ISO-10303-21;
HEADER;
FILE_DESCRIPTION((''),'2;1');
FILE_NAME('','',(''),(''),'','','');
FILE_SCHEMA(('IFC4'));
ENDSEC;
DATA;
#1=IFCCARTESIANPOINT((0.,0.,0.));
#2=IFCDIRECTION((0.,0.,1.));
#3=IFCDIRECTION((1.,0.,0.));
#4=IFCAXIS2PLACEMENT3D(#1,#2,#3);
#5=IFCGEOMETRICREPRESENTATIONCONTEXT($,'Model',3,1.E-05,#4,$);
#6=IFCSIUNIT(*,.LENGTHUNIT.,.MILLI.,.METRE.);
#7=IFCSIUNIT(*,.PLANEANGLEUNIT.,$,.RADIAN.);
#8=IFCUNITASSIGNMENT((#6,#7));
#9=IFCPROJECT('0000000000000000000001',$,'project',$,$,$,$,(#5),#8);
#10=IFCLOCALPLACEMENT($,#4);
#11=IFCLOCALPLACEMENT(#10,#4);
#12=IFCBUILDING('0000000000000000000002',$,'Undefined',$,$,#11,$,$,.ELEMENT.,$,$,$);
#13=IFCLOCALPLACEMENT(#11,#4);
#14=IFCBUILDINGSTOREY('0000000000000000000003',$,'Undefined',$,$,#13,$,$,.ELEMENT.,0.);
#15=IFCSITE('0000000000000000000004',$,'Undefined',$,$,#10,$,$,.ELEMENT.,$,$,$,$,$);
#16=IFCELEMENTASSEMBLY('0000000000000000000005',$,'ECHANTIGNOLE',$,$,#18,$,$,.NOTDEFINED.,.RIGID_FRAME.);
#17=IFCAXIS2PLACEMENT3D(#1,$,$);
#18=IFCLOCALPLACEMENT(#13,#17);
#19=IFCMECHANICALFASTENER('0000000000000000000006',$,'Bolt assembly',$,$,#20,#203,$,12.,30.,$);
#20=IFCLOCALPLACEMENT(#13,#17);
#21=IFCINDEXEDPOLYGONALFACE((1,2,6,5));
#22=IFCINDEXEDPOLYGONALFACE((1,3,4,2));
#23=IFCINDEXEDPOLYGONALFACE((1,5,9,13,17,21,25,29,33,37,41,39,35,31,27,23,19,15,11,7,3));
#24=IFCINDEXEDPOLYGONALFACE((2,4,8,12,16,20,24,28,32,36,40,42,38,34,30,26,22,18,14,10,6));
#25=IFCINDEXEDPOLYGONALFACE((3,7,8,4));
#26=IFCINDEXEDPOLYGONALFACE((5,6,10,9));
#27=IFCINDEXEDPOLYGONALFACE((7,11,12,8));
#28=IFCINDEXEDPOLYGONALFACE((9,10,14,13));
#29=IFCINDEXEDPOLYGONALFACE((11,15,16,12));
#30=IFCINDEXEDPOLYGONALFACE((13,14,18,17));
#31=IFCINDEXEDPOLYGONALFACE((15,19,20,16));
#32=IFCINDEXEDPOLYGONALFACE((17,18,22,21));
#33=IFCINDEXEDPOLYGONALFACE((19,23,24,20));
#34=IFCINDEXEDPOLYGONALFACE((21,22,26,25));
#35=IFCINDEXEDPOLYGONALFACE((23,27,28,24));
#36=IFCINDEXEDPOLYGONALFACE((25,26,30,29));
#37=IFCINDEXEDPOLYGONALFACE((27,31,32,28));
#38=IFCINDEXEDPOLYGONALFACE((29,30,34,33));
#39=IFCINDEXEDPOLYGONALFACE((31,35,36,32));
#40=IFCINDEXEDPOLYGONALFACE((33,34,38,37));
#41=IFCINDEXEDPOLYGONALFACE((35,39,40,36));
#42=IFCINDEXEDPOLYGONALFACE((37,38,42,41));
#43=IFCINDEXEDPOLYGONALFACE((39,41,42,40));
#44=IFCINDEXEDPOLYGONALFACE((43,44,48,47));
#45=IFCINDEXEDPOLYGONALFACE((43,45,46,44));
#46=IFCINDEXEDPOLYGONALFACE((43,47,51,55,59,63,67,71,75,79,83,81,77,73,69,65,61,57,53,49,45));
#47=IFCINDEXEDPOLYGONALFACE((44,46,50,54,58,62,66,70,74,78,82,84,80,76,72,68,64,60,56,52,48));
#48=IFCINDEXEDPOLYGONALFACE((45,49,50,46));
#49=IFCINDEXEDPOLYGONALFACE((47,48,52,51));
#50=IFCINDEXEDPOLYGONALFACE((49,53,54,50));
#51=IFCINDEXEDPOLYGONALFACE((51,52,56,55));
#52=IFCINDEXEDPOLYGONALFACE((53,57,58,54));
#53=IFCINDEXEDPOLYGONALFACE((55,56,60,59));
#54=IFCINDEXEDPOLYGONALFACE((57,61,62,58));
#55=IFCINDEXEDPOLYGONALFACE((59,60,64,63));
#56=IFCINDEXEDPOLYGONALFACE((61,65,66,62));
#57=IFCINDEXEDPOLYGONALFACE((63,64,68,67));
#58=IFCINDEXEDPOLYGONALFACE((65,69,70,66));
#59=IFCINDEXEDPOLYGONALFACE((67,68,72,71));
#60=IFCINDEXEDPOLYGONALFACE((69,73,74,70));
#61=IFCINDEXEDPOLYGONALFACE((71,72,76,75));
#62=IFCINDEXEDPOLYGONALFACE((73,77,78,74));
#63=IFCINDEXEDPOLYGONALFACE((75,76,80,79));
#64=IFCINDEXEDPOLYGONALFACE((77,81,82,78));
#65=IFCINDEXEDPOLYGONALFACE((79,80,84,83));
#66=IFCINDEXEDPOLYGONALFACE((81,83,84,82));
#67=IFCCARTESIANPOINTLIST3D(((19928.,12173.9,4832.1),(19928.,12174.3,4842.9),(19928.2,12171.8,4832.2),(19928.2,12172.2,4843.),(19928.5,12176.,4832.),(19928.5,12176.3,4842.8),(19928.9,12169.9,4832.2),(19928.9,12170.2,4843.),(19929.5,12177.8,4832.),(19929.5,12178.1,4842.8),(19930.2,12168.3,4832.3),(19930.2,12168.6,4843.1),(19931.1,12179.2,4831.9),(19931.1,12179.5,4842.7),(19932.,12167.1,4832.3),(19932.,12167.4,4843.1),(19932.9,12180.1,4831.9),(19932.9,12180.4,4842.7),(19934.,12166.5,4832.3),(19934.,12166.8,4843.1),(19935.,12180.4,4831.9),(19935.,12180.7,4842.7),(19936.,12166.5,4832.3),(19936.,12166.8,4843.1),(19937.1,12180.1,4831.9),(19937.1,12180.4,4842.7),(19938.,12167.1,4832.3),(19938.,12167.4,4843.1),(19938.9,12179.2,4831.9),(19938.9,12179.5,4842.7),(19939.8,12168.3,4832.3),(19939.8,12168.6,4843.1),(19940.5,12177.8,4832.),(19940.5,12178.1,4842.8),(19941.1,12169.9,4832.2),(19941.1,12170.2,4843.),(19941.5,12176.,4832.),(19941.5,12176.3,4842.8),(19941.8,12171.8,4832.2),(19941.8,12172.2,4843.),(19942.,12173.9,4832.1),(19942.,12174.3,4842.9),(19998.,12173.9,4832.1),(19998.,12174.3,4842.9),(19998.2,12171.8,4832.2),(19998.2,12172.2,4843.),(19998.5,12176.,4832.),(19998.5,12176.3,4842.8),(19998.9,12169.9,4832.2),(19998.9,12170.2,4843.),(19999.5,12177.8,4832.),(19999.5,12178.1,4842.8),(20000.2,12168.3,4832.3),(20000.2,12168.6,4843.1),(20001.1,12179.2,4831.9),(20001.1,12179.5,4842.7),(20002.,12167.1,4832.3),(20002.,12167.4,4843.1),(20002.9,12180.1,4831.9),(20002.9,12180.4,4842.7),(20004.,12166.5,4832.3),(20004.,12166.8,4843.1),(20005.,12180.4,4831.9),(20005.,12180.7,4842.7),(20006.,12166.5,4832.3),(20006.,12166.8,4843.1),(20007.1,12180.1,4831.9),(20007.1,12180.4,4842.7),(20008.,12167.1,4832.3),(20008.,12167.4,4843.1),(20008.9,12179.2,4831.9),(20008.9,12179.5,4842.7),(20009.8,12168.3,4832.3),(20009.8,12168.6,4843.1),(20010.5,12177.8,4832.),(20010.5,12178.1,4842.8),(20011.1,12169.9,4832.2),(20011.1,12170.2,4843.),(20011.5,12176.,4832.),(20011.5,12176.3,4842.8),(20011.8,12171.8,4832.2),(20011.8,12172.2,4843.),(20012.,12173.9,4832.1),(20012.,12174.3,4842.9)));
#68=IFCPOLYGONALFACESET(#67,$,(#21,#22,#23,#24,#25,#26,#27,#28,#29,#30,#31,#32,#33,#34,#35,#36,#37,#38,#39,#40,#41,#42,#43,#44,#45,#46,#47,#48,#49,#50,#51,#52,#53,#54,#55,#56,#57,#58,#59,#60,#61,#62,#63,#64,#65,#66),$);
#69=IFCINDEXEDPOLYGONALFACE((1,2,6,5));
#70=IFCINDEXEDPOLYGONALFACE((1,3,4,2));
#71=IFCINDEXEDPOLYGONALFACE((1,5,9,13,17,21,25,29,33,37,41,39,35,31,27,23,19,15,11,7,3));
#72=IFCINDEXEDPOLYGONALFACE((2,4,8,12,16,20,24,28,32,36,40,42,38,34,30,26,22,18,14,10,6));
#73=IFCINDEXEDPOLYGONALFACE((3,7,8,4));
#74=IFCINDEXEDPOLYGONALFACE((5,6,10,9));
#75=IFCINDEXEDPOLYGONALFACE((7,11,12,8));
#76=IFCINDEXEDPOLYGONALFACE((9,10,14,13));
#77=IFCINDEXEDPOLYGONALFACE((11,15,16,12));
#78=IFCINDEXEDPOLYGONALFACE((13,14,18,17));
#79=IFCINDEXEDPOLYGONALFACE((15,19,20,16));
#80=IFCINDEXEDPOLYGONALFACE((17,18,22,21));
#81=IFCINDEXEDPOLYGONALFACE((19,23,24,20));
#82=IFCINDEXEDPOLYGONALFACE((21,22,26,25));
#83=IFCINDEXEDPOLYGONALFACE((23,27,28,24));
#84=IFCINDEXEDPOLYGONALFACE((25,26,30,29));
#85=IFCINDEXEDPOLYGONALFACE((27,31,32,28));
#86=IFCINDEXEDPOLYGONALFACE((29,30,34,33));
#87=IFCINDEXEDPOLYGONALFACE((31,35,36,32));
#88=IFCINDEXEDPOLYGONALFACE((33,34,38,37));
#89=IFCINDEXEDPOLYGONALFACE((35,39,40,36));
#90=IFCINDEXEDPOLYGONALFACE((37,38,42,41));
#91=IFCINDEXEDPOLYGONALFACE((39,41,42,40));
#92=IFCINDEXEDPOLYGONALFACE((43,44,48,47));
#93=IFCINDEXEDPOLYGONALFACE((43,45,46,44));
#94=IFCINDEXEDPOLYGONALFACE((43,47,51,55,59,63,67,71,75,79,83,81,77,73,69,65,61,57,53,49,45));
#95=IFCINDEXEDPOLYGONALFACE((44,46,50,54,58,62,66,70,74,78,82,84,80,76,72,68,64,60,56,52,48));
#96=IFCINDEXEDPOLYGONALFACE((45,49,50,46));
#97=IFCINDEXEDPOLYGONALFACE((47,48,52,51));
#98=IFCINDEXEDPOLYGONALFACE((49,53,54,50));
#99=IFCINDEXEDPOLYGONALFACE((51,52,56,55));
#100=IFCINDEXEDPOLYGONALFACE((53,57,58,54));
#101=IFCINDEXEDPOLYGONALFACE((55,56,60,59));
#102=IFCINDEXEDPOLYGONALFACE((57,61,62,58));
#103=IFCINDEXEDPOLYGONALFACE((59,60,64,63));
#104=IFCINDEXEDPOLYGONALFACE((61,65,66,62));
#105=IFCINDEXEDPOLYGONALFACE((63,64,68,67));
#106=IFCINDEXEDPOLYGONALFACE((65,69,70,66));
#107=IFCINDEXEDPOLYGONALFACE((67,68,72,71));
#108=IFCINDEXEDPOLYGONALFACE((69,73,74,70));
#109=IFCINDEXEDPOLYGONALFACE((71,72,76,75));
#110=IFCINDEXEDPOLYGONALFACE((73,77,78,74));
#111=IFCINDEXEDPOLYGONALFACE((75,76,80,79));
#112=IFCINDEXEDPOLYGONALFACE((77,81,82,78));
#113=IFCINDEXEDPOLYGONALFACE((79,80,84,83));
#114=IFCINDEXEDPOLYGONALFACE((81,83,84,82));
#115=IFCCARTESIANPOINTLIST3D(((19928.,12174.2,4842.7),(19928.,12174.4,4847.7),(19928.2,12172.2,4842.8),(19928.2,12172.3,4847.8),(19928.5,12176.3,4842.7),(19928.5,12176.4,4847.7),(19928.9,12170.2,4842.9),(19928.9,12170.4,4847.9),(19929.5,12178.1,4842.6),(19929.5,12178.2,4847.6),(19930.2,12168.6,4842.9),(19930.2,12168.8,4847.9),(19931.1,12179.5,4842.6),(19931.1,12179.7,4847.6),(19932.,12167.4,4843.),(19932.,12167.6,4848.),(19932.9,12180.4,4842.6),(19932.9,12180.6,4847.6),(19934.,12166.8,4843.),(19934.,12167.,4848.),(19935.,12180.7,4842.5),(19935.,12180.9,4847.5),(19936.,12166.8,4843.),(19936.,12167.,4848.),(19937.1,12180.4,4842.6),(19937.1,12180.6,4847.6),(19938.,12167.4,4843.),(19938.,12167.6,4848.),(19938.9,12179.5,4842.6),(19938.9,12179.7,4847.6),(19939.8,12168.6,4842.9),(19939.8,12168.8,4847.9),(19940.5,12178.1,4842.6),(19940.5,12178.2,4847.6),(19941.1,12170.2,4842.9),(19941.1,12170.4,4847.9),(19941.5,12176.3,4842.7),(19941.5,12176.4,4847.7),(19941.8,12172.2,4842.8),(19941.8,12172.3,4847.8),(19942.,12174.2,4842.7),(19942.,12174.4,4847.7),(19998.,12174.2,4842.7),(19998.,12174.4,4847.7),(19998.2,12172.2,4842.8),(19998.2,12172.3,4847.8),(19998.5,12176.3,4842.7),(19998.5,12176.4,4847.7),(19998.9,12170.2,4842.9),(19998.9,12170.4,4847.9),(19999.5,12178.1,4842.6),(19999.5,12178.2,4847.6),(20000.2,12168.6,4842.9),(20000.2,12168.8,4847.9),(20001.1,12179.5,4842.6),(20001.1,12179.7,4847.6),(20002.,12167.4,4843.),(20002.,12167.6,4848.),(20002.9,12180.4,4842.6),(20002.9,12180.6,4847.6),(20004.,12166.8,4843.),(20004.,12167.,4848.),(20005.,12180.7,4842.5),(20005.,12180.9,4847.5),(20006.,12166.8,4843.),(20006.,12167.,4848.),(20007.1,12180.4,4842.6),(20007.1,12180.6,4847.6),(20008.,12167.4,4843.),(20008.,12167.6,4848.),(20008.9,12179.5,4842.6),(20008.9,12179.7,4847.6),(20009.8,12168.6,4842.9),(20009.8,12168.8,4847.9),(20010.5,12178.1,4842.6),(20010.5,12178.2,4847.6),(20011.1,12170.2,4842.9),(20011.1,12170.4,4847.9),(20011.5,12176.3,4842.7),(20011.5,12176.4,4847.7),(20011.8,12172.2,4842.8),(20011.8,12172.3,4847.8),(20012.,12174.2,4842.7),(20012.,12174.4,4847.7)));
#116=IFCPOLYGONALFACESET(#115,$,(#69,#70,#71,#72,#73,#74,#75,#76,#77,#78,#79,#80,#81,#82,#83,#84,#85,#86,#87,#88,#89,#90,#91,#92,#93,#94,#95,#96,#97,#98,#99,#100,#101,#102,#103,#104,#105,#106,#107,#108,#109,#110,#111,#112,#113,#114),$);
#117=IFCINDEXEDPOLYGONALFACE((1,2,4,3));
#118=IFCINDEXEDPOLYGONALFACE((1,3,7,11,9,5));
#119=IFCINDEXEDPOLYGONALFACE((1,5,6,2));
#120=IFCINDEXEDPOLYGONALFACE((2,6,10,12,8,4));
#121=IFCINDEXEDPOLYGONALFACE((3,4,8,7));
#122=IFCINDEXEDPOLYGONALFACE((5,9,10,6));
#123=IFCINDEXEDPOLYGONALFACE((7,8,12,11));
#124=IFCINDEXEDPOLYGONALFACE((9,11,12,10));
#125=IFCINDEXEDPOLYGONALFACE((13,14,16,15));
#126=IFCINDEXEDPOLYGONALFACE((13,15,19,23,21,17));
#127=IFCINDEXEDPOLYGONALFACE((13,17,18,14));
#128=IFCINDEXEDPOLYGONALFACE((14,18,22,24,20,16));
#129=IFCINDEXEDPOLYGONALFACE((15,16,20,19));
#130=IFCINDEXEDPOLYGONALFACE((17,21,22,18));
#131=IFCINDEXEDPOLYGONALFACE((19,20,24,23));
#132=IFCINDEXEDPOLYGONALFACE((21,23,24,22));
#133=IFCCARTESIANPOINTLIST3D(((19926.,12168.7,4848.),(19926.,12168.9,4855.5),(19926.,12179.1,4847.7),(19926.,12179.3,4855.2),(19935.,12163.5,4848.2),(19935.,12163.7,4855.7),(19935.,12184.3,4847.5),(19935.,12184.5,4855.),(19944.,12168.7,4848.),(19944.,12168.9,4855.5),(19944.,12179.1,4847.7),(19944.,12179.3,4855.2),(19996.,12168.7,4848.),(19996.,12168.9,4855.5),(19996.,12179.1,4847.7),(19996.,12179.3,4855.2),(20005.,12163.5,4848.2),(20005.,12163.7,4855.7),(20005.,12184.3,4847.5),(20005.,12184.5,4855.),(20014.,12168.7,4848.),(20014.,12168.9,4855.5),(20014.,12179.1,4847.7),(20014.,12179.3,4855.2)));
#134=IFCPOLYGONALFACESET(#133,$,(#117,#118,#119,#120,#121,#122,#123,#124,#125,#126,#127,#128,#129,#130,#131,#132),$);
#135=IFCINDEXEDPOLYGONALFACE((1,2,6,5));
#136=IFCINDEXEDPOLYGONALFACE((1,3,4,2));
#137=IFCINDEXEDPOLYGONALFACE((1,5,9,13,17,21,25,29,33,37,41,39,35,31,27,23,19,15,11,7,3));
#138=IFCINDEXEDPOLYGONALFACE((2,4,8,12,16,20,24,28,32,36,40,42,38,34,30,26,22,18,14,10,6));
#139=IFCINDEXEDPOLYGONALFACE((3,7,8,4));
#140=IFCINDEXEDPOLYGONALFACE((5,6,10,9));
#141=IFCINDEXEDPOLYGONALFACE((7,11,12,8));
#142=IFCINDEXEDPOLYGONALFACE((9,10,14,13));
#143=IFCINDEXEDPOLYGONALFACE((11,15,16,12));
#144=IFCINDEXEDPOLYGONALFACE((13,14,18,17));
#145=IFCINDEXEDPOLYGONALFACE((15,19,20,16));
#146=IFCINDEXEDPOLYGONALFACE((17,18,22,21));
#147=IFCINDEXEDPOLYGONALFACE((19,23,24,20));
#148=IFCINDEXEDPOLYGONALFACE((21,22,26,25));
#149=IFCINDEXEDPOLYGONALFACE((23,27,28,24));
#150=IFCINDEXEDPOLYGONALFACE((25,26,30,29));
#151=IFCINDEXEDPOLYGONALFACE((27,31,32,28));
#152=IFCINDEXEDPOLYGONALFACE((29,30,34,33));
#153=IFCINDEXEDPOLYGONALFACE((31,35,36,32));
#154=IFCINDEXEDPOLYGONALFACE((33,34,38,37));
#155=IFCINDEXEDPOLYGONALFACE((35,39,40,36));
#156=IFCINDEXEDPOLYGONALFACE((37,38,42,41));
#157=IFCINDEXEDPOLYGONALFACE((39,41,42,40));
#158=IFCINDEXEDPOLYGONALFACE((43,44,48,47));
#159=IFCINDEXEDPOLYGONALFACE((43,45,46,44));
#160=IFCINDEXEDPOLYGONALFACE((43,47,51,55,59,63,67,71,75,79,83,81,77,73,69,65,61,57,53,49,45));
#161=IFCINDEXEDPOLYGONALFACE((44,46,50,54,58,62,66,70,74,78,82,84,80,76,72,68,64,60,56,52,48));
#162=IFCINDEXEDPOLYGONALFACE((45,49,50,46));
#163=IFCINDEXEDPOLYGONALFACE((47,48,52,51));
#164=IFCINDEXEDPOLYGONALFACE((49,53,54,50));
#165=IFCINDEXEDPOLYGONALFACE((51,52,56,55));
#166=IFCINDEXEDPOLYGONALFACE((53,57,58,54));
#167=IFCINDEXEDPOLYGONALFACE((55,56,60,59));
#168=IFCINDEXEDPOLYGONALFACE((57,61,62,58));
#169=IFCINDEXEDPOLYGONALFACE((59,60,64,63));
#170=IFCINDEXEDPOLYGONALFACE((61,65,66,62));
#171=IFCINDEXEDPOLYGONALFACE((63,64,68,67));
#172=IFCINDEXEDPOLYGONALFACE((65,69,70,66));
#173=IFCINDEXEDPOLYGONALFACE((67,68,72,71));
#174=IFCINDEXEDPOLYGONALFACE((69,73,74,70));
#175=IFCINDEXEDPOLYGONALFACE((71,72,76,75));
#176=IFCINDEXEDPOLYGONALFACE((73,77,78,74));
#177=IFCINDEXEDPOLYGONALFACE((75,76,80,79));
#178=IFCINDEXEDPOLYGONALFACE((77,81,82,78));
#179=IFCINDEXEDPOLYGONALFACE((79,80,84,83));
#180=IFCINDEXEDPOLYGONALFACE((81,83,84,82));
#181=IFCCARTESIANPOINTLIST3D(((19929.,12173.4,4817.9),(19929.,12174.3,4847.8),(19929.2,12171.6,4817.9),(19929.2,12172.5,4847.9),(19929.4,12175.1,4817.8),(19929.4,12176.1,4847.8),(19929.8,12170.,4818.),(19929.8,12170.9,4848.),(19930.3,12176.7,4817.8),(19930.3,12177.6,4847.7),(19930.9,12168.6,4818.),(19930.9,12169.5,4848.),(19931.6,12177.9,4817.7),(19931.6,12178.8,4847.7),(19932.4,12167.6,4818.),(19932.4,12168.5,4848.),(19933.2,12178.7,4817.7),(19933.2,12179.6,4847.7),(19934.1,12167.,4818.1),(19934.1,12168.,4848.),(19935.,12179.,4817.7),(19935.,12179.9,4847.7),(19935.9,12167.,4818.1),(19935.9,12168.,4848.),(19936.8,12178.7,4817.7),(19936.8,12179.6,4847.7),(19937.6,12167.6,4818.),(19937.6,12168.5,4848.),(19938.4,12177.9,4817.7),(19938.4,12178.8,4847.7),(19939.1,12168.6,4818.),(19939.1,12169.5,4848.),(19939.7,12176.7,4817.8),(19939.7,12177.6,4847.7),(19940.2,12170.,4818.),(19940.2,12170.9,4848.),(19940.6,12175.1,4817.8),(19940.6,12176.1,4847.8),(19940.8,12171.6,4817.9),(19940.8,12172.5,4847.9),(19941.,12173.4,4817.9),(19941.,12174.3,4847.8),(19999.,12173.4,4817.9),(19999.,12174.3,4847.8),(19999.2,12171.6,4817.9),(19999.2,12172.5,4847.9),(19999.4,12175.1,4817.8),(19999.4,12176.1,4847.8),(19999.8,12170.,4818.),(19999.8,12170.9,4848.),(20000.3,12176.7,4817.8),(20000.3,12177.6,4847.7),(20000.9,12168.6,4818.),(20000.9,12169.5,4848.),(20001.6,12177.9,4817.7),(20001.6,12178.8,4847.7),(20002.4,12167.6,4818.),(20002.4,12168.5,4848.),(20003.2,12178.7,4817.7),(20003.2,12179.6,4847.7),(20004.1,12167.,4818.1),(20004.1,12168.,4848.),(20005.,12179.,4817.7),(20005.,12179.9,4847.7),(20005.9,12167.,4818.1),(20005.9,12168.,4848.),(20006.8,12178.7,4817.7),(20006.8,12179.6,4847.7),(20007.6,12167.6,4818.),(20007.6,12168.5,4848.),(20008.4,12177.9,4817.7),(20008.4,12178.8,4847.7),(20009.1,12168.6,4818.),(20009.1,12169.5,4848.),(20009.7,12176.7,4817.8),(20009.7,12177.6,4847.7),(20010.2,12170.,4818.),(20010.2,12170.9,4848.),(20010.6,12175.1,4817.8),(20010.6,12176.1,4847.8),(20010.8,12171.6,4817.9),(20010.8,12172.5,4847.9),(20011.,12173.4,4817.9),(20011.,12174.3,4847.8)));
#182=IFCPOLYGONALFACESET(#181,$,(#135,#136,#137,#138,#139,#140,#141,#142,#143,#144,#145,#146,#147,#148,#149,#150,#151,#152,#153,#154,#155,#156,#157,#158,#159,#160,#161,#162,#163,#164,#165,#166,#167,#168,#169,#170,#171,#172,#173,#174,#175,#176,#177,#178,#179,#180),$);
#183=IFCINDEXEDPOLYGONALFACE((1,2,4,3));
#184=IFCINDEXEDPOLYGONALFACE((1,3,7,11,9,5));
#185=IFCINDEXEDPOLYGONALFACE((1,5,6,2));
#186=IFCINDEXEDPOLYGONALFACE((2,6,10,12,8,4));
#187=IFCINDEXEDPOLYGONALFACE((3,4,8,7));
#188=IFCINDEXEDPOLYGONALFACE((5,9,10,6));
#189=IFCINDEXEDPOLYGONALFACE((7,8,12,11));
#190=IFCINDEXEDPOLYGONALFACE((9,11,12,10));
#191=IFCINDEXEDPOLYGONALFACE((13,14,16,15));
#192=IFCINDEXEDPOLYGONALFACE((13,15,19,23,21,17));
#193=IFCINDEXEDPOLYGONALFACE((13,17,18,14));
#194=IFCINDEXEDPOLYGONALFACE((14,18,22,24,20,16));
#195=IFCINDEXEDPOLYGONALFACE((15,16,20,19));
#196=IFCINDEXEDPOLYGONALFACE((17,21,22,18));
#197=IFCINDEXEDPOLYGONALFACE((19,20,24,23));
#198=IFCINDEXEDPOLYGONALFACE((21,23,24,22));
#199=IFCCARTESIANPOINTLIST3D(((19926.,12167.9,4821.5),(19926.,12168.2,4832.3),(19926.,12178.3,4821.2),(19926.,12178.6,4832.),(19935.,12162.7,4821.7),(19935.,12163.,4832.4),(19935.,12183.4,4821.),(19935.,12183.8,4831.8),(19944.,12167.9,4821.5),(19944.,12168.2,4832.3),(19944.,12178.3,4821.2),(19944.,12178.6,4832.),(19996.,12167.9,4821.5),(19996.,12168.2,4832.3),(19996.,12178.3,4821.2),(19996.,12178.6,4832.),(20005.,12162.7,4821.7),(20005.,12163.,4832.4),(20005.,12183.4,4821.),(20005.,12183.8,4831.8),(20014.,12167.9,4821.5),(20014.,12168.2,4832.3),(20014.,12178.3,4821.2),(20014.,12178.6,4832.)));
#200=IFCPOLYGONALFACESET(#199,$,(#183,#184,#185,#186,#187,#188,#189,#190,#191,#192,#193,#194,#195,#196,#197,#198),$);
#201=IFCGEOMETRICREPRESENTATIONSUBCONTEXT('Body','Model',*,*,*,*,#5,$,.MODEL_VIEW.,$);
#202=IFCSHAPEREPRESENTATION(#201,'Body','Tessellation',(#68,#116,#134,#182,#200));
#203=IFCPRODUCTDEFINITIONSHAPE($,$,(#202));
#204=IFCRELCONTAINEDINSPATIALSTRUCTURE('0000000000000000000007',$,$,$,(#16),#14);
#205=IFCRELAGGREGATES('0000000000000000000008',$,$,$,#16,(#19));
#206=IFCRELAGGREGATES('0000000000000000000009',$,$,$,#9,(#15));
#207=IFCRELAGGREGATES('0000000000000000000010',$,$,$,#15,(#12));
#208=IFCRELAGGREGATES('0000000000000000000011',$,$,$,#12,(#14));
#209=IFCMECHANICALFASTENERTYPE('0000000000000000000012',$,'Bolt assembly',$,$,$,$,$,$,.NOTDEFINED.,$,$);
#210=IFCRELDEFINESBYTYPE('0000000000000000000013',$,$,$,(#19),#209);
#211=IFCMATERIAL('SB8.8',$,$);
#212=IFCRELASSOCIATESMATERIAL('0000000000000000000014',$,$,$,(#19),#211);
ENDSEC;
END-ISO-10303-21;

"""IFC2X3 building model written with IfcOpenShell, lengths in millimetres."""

from ifc_helpers import new_model, si_unit, frame, origin_with_axes, origin_2d_with_axis, place, context, subcontext, project, spatial, polyline, circle, outline, extrude, source, transform, mapped, material, type_object, element, aggregate, save


model = new_model("IFC2X3")

# Units and contexts
model_context = context("Model", 3, precision=1e-05, world=origin_with_axes())
body_context = subcontext(model_context, "Body", "Model", "MODEL_VIEW")
ifc_project = project(units=[si_unit("LENGTHUNIT", "METRE", prefix="MILLI"), si_unit("PLANEANGLEUNIT", "RADIAN")], contexts=[model_context])

# Site, building, storey
site_placement = place(None, origin_with_axes())
site = spatial("IfcSite", under=ifc_project, at=site_placement, Name="Undefined", CompositionType="ELEMENT")
building_placement = place(site_placement, origin_with_axes())
building = spatial("IfcBuilding", under=site, at=building_placement, Name="Undefined", CompositionType="ELEMENT")
storey_placement = place(building_placement, origin_with_axes())
storey = spatial("IfcBuildingStorey", under=building, at=storey_placement, Name="Undefined", CompositionType="ELEMENT", Elevation=0.0)

# Element assembly, mechanical fastener
assembly_1_placement = place(storey_placement, origin_with_axes())
assembly_1 = element("IfcElementAssembly", 1, at=assembly_1_placement, inside=storey, Name="ECHANTIGNOLE", AssemblyPlace="NOTDEFINED", PredefinedType="RIGID_FRAME")
ifc_material_1 = material(Name="SB8.8")
mechanical_fastener_type = type_object("IfcMechanicalFastenerType", Name="Bolt assembly")
shared_shape_1 = source(origin_with_axes(), body_context, "Body", "SweptSolid", [
    extrude(circle(Radius=7.0, at=origin_2d_with_axis()), frame((0.0, -0.1, 0.0), z_axis=(0.0, 1.0, 0.0), x_axis=(1.0, 0.0, 0.0)), (0.0, 0.0, 1.0), 10.8),
    extrude(circle(Radius=7.0, at=origin_2d_with_axis()), frame((0.0, -4.9, 0.0), z_axis=(0.0, 1.0, 0.0), x_axis=(1.0, 0.0, 0.0)), (0.0, 0.0, 1.0), 5.0),
    extrude(outline(polyline([(10.4, 0.0), (5.2, 9.0), (-5.2, 9.0), (-10.4, 0.0), (-5.2, -9.0), (5.2, -9.0), (10.4, 0.0)])), frame((0.0, -12.5, 0.0), z_axis=(0.0, 1.0, 0.0), x_axis=(1.0, 0.0, 0.0)), (0.0, 0.0, 1.0), 7.5),
    extrude(circle(Radius=6.0, at=origin_2d_with_axis()), frame((0.0, -5.0, 0.0), z_axis=(0.0, 1.0, 0.0), x_axis=(1.0, 0.0, 0.0)), (0.0, 0.0, 1.0), 30.0),
    extrude(outline(polyline([(10.4, 0.0), (5.2, 9.0), (-5.2, 9.0), (-10.4, 0.0), (-5.2, -9.0), (5.2, -9.0), (10.4, 0.0)])), frame((0.0, 10.7, 0.0), z_axis=(0.0, 1.0, 0.0), x_axis=(1.0, 0.0, 0.0)), (0.0, 0.0, 1.0), 10.8),
])
mechanical_fastener_1_placement = place(assembly_1_placement, frame((19970.0, 12173.7, 4842.9), z_axis=(-1.0, 0.0, 0.0), x_axis=(0.0, 0.99952, -0.030986)))
mechanical_fastener_1 = element("IfcMechanicalFastener", 2, at=mechanical_fastener_1_placement, type_object=mechanical_fastener_type, material=ifc_material_1, Name="Bolt assembly", NominalDiameter=12.0, NominalLength=30.0, context=body_context, shape_type="MappedRepresentation", body=[
    mapped(shared_shape_1, transform((0.0, 0.0, 35.0))),
    mapped(shared_shape_1, transform((0.0, 0.0, -35.0))),
])
aggregate(assembly_1, [mechanical_fastener_1])

save(model, "model.ifc")
